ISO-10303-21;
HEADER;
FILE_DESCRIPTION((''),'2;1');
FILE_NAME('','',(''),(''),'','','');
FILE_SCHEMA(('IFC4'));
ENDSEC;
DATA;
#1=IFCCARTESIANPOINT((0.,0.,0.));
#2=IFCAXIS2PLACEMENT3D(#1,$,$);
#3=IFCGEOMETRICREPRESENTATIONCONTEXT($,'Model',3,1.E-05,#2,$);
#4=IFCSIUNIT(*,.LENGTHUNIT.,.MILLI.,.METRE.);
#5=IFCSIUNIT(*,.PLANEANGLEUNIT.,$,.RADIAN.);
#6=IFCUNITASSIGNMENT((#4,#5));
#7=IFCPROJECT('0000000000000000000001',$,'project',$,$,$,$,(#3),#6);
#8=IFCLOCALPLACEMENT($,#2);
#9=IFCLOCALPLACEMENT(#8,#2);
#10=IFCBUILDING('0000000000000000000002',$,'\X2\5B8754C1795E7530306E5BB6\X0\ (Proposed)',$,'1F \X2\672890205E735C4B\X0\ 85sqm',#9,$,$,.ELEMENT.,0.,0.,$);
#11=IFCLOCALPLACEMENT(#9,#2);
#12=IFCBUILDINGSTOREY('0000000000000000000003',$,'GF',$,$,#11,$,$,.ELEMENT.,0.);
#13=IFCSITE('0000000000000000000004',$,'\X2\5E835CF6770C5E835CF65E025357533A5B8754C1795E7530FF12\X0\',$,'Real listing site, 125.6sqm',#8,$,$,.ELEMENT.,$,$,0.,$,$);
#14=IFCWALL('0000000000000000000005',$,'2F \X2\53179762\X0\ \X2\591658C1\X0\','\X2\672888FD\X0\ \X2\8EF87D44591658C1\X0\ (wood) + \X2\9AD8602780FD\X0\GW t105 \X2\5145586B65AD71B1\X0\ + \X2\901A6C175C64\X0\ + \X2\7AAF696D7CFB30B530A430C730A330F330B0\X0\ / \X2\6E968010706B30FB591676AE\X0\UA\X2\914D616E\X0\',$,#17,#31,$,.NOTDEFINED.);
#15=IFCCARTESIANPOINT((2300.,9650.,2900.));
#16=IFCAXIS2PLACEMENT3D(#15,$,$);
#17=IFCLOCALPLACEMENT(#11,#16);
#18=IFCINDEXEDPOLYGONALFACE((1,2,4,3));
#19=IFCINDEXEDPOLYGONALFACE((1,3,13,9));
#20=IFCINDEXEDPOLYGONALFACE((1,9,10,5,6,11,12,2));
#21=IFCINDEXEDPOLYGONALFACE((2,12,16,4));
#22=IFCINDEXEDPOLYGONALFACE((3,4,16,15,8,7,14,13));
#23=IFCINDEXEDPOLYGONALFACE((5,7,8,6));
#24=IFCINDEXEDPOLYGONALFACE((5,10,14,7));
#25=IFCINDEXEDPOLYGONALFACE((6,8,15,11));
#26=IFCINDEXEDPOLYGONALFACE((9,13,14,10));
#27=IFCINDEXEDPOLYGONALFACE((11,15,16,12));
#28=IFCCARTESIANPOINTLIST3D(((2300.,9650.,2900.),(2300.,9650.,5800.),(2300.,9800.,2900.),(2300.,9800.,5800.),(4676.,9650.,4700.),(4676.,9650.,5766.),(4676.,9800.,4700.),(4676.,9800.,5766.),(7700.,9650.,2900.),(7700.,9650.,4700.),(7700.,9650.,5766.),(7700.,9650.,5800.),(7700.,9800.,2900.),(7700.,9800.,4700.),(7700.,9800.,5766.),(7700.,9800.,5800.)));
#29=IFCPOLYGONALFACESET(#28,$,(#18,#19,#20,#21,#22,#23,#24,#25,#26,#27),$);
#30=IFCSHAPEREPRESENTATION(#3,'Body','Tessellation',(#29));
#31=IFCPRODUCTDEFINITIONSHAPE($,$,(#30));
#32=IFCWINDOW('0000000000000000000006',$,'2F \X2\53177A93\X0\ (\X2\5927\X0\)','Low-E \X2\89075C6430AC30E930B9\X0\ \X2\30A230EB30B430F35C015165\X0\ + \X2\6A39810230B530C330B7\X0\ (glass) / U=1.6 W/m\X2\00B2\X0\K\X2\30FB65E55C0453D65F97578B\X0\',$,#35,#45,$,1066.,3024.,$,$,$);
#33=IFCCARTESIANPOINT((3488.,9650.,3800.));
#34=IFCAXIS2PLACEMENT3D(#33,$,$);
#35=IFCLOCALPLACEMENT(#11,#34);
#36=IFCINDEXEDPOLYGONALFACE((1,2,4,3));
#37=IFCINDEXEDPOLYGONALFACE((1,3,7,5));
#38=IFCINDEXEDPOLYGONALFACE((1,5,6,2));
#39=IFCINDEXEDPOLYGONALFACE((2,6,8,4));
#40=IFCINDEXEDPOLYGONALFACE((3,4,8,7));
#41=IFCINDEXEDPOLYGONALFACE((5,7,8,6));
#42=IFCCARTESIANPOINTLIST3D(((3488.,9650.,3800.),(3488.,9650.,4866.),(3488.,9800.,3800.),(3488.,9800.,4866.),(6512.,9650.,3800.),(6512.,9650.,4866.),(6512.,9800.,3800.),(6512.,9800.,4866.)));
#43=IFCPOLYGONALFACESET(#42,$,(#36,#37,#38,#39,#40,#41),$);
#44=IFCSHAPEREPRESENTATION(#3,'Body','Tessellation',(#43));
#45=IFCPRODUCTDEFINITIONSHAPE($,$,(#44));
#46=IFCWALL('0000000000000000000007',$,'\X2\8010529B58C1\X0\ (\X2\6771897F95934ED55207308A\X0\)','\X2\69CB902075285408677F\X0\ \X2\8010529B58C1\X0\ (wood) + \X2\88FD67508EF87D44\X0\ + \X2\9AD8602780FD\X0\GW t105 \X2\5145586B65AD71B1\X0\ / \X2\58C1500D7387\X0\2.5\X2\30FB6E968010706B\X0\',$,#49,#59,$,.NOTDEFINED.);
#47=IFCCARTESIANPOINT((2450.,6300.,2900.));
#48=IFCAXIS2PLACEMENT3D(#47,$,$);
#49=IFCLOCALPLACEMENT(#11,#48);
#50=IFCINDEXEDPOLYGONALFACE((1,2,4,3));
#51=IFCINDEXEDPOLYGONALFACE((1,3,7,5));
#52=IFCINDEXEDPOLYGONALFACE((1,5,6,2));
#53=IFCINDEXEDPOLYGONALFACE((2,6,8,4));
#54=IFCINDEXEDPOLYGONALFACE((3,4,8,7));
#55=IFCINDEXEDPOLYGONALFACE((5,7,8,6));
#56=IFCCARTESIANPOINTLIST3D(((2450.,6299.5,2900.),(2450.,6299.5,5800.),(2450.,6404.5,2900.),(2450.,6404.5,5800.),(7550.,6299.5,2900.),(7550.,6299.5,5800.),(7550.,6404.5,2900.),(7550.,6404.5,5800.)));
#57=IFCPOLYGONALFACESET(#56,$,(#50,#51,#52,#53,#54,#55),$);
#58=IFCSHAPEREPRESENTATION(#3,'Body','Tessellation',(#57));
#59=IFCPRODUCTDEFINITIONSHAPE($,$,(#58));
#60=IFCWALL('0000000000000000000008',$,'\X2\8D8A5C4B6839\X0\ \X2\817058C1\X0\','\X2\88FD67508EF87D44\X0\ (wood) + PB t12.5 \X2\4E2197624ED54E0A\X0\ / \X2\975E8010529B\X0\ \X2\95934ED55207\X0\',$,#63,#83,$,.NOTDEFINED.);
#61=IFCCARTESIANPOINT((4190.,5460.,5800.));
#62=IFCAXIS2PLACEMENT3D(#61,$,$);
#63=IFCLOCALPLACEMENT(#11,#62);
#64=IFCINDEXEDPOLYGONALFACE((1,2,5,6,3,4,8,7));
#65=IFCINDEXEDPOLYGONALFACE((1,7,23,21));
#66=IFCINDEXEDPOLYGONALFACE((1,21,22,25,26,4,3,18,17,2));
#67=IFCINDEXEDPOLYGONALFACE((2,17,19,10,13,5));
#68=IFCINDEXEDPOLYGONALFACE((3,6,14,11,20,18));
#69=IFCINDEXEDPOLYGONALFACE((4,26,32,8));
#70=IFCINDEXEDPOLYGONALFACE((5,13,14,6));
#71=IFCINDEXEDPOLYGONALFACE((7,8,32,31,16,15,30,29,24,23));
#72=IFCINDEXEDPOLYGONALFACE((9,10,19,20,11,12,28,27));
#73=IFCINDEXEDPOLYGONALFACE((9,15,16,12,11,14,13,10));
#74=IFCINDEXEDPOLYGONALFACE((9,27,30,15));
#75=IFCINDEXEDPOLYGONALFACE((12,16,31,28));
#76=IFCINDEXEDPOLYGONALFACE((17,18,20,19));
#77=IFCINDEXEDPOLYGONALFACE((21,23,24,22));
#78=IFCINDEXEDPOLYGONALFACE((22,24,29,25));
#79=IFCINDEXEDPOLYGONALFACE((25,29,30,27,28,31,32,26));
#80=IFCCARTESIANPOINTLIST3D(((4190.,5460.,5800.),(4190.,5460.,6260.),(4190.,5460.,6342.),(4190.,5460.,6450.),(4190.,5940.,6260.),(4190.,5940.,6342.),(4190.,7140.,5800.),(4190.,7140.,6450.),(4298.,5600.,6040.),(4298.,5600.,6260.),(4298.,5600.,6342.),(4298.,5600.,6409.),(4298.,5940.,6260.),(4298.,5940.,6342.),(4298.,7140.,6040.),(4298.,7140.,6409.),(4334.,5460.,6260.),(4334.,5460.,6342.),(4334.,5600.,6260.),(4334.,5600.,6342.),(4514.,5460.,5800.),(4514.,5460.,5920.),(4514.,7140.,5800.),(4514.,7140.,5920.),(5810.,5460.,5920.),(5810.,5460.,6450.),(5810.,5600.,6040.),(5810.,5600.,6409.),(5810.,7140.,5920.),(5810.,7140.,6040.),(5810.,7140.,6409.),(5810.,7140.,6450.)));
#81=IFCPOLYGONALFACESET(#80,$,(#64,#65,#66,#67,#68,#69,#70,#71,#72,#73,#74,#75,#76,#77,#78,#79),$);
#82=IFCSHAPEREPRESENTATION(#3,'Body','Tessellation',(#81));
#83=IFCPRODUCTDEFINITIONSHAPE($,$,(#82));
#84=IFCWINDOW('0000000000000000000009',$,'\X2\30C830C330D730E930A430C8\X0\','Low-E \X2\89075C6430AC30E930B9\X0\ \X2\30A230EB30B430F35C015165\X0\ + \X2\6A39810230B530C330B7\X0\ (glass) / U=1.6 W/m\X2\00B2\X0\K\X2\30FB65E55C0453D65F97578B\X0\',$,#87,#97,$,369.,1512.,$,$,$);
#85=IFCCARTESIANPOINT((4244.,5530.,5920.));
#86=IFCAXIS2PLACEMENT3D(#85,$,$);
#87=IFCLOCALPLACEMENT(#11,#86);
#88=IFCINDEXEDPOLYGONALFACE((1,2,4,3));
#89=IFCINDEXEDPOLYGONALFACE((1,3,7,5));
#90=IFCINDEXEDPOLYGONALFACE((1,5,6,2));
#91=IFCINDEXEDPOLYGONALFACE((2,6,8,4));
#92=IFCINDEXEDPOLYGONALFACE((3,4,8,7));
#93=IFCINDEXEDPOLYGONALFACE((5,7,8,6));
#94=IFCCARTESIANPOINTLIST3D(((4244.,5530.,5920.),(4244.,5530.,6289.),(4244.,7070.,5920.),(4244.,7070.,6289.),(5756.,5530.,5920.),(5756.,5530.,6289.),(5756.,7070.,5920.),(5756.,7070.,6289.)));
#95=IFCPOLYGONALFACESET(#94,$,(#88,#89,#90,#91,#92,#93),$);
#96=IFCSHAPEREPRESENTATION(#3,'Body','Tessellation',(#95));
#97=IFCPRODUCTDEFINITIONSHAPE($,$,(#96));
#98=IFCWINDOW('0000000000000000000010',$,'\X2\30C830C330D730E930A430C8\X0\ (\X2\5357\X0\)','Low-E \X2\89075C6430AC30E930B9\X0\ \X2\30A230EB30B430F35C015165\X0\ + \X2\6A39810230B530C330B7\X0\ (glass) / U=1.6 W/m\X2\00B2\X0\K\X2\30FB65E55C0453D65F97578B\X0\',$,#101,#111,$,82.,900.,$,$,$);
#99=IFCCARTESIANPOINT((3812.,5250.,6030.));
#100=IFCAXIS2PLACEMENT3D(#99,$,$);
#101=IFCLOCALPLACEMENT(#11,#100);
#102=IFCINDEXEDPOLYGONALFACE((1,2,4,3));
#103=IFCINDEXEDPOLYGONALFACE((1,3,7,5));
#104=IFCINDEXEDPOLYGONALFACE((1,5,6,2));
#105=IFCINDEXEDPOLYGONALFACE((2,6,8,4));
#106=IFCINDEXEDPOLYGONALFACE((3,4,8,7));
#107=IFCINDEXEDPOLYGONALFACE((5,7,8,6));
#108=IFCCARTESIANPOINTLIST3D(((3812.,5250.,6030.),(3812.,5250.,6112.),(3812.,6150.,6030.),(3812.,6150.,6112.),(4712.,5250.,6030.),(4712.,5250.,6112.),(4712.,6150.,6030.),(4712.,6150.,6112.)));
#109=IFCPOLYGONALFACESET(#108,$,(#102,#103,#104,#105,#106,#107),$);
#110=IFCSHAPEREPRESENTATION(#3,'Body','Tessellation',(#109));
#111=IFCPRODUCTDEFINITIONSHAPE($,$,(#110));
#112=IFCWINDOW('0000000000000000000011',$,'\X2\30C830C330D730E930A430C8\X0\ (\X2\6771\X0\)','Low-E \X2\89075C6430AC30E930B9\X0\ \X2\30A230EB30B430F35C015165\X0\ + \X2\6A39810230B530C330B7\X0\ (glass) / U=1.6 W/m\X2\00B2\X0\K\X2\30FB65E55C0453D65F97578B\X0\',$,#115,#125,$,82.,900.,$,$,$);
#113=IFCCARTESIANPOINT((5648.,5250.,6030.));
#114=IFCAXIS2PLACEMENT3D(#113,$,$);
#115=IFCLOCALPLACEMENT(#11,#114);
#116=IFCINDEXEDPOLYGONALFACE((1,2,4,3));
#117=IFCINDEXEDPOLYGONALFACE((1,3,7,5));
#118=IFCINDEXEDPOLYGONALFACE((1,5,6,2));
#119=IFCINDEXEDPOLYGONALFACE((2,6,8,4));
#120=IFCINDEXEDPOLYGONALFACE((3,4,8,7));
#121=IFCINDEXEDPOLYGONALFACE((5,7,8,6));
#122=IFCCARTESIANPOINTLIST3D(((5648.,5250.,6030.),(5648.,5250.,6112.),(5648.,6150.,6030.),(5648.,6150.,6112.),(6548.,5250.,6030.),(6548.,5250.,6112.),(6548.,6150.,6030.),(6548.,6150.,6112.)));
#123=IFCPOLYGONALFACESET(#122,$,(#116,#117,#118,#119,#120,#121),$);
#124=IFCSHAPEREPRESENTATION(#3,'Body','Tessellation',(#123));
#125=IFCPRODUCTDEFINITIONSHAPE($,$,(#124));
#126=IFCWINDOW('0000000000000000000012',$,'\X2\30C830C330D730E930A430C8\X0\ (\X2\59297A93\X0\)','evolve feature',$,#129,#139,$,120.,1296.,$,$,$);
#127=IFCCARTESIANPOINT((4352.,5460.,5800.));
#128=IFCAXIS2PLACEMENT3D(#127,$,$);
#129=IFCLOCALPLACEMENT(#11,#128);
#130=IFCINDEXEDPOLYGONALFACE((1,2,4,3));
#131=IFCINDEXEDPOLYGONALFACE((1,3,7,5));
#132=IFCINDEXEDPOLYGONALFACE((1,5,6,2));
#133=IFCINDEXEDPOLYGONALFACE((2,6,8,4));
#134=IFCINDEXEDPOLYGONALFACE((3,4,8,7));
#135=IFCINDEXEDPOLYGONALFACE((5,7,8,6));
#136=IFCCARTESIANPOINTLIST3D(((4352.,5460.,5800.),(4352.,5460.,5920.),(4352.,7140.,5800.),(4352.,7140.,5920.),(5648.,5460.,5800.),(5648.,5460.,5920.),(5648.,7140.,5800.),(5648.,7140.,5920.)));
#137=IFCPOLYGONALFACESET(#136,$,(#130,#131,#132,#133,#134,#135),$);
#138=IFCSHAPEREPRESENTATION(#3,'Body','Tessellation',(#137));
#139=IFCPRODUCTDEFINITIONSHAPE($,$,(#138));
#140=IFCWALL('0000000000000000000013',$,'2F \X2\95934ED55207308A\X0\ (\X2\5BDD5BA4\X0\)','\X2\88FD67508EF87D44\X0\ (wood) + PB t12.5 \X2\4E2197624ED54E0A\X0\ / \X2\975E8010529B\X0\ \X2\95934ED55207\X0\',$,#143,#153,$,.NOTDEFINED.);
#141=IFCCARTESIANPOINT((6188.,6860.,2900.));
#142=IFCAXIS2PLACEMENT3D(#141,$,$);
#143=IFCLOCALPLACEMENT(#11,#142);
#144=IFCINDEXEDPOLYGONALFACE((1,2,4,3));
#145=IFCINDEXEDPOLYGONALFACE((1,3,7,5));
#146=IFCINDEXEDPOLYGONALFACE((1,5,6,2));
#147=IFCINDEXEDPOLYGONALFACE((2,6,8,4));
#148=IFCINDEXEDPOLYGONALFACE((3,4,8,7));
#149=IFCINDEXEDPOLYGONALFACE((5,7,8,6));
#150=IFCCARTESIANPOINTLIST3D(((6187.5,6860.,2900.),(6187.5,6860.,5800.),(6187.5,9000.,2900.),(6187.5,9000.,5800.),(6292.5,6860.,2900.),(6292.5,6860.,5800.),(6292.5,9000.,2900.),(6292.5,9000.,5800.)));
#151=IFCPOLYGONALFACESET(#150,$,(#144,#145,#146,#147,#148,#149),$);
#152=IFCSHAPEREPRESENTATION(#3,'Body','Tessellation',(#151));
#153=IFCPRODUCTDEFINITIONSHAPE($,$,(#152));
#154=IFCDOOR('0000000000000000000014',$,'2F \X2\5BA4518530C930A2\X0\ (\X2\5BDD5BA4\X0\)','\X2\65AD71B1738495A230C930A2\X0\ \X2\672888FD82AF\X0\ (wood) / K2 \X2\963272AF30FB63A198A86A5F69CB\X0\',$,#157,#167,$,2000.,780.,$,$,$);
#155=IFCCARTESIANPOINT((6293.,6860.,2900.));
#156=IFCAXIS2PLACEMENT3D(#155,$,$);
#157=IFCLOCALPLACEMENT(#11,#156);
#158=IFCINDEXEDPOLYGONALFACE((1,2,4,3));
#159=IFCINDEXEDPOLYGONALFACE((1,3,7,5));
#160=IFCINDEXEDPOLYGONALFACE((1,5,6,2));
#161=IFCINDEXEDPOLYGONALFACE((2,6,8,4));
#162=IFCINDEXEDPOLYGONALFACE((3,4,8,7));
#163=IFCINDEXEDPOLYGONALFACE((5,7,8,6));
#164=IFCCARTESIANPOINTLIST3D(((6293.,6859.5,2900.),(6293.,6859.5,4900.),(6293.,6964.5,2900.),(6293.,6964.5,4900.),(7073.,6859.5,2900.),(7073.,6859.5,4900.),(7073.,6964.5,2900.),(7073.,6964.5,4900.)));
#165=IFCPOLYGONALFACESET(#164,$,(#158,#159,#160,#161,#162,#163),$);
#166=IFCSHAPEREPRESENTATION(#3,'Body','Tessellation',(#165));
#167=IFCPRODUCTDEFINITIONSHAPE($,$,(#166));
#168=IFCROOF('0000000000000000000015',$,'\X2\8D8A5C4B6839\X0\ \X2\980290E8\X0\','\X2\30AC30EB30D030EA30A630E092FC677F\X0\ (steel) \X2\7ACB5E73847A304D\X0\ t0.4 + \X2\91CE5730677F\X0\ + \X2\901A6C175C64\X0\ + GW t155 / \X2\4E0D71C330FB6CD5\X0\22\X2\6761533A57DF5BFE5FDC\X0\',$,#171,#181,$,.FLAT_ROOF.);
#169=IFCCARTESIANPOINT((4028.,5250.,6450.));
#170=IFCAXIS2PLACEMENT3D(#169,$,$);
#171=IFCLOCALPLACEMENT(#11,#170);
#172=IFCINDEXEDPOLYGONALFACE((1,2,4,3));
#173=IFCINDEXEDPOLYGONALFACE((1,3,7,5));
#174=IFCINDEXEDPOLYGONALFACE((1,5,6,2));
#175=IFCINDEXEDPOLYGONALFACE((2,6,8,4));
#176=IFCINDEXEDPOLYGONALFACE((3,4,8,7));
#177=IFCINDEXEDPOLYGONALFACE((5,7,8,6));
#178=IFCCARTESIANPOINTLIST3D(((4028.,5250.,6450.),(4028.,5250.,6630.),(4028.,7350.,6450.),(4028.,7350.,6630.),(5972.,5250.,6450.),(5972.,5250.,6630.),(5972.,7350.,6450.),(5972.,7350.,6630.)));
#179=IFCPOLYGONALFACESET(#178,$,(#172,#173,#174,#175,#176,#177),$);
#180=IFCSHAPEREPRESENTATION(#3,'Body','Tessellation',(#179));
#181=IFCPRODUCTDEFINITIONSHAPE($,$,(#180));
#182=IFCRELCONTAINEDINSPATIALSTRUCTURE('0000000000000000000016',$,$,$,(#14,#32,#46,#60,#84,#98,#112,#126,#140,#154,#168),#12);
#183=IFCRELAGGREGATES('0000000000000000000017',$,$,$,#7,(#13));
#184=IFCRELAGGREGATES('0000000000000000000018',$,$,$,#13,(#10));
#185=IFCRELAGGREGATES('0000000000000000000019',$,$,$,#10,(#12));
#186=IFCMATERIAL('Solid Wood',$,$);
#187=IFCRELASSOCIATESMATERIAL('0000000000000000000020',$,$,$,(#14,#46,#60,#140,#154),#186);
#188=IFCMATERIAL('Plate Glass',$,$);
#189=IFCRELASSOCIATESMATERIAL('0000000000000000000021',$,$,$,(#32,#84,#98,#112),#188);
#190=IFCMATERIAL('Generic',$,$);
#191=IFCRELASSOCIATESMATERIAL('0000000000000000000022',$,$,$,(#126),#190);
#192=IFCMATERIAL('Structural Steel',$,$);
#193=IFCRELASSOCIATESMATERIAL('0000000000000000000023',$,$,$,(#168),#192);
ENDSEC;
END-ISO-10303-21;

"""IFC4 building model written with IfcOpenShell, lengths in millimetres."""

from ifc_helpers import new_model, si_unit, frame, frame_2d, origin, place, context, project, spatial, rectangle, extrude, material, element, fill, save


model = new_model("IFC4")

# Units and contexts
model_context = context("Model", 3, precision=1e-05, world=origin())
ifc_project = project(units=[si_unit("LENGTHUNIT", "METRE", prefix="MILLI"), si_unit("PLANEANGLEUNIT", "RADIAN")], contexts=[model_context])

# Site, building, storey
site_placement = place(None, origin())
site = spatial("IfcSite", under=ifc_project, at=site_placement, Name="広島県広島市南区宇品神田２", ObjectType="Real listing site, 125.6sqm", CompositionType="ELEMENT", RefElevation=0.0)
building_placement = place(site_placement, origin())
building = spatial("IfcBuilding", under=site, at=building_placement, Name="宇品神田の家 (Proposed)", ObjectType="1F 木造平屋 85sqm", CompositionType="ELEMENT", ElevationOfRefHeight=0.0, ElevationOfTerrain=0.0)
storey_placement = place(building_placement, origin())
storey = spatial("IfcBuildingStorey", under=building, at=storey_placement, Name="GF", CompositionType="ELEMENT", Elevation=0.0)

# Wall, opening, window
ifc_material_1 = material(Name="Solid Wood")
wall_1_placement = place(storey_placement, frame((2300.0, 9650.0, 2900.0)))
wall_1 = element("IfcWall", 1, at=wall_1_placement, inside=storey, material=ifc_material_1, Name="2F 北面 外壁", Description="木製 軸組外壁 (wood) + 高性能GW t105 充填断熱 + 通気層 + 窯業系サイディング / 準耐火・外皮UA配慮", PredefinedType="NOTDEFINED", context=model_context, shape_type="SweptSolid", body=[
    extrude(rectangle(XDim=5400.0, YDim=150.0, at=frame_2d((2700.0, 75.0))), frame((2300.0, 9650.0, 2900.0)), (0.0, 0.0, 1.0), 2900.0),
])
opening_1_placement = place(storey_placement, frame((3488.0, 9650.0, 3800.0)))
opening_1 = element("IfcOpeningElement", 2, at=opening_1_placement, cuts=wall_1, PredefinedType="NOTDEFINED", context=model_context, shape_type="SweptSolid", body=[
    extrude(rectangle(XDim=3024.0, YDim=150.0, at=frame_2d((1512.0, 75.0))), frame((3488.0, 9650.0, 3800.0)), (0.0, 0.0, 1.0), 1066.0),
])
ifc_material_2 = material(Name="Plate Glass")
window_1_placement = place(storey_placement, frame((3488.0, 9650.0, 3800.0)))
window_1 = element("IfcWindow", 3, at=window_1_placement, inside=storey, material=ifc_material_2, Name="2F 北窓 (大)", Description="Low-E 複層ガラス アルゴン封入 + 樹脂サッシ (glass) / U=1.6 W/m²K・日射取得型", OverallHeight=1066.0, OverallWidth=3024.0, context=model_context, shape_type="SweptSolid", body=[
    extrude(rectangle(XDim=3024.0, YDim=150.0, at=frame_2d((1512.0, 75.0))), frame((3488.0, 9650.0, 3800.0)), (0.0, 0.0, 1.0), 1066.0),
])
fill(opening_1, window_1)

# Wall
wall_2_placement = place(storey_placement, frame((2450.0, 6300.0, 2900.0)))
element("IfcWall", 4, at=wall_2_placement, inside=storey, material=ifc_material_1, Name="耐力壁 (東西間仕切り)", Description="構造用合板 耐力壁 (wood) + 製材軸組 + 高性能GW t105 充填断熱 / 壁倍率2.5・準耐火", PredefinedType="NOTDEFINED", context=model_context, shape_type="SweptSolid", body=[
    extrude(rectangle(XDim=5100.0, YDim=105.0, at=frame_2d((2550.0, 52.0))), frame((2450.0, 6300.0, 2900.0)), (0.0, 0.0, 1.0), 2900.0),
])

# Wall, openings, windows
wall_3_placement = place(storey_placement, frame((4190.0, 5460.0, 5800.0)))
wall_3 = element("IfcWall", 5, at=wall_3_placement, inside=storey, material=ifc_material_1, Name="越屋根 腰壁", Description="製材軸組 (wood) + PB t12.5 両面仕上 / 非耐力 間仕切", PredefinedType="NOTDEFINED", context=model_context, shape_type="SweptSolid", body=[
    extrude(rectangle(XDim=1620.0, YDim=1680.0, at=frame_2d((810.0, 840.0))), frame((4190.0, 5460.0, 5800.0)), (0.0, 0.0, 1.0), 650.0),
])
opening_2_placement = place(storey_placement, frame((4244.0, 5530.0, 5920.0)))
opening_2 = element("IfcOpeningElement", 6, at=opening_2_placement, cuts=wall_3, PredefinedType="NOTDEFINED", context=model_context, shape_type="SweptSolid", body=[
    extrude(rectangle(XDim=1512.0, YDim=1540.0, at=frame_2d((756.0, 770.0))), frame((4244.0, 5530.0, 5920.0)), (0.0, 0.0, 1.0), 369.0),
])
opening_3_placement = place(storey_placement, frame((3812.0, 5250.0, 6030.0)))
opening_3 = element("IfcOpeningElement", 7, at=opening_3_placement, cuts=wall_3, PredefinedType="NOTDEFINED", context=model_context, shape_type="SweptSolid", body=[
    extrude(rectangle(XDim=900.0, YDim=900.0, at=frame_2d((450.0, 450.0))), frame((3812.0, 5250.0, 6030.0)), (0.0, 0.0, 1.0), 82.0),
])
opening_4_placement = place(storey_placement, frame((5648.0, 5250.0, 6030.0)))
opening_4 = element("IfcOpeningElement", 8, at=opening_4_placement, cuts=wall_3, PredefinedType="NOTDEFINED", context=model_context, shape_type="SweptSolid", body=[
    extrude(rectangle(XDim=900.0, YDim=900.0, at=frame_2d((450.0, 450.0))), frame((5648.0, 5250.0, 6030.0)), (0.0, 0.0, 1.0), 82.0),
])
opening_5_placement = place(storey_placement, frame((4352.0, 5460.0, 5800.0)))
opening_5 = element("IfcOpeningElement", 9, at=opening_5_placement, cuts=wall_3, PredefinedType="NOTDEFINED", context=model_context, shape_type="SweptSolid", body=[
    extrude(rectangle(XDim=1296.0, YDim=1680.0, at=frame_2d((648.0, 840.0))), frame((4352.0, 5460.0, 5800.0)), (0.0, 0.0, 1.0), 120.0),
])
window_2_placement = place(storey_placement, frame((4244.0, 5530.0, 5920.0)))
window_2 = element("IfcWindow", 10, at=window_2_placement, inside=storey, material=ifc_material_2, Name="トップライト", Description="Low-E 複層ガラス アルゴン封入 + 樹脂サッシ (glass) / U=1.6 W/m²K・日射取得型", OverallHeight=369.0, OverallWidth=1512.0, context=model_context, shape_type="SweptSolid", body=[
    extrude(rectangle(XDim=1512.0, YDim=1540.0, at=frame_2d((756.0, 770.0))), frame((4244.0, 5530.0, 5920.0)), (0.0, 0.0, 1.0), 369.0),
])
fill(opening_2, window_2)
window_3_placement = place(storey_placement, frame((3812.0, 5250.0, 6030.0)))
window_3 = element("IfcWindow", 11, at=window_3_placement, inside=storey, material=ifc_material_2, Name="トップライト (南)", Description="Low-E 複層ガラス アルゴン封入 + 樹脂サッシ (glass) / U=1.6 W/m²K・日射取得型", OverallHeight=82.0, OverallWidth=900.0, context=model_context, shape_type="SweptSolid", body=[
    extrude(rectangle(XDim=900.0, YDim=900.0, at=frame_2d((450.0, 450.0))), frame((3812.0, 5250.0, 6030.0)), (0.0, 0.0, 1.0), 82.0),
])
fill(opening_3, window_3)
window_4_placement = place(storey_placement, frame((5648.0, 5250.0, 6030.0)))
window_4 = element("IfcWindow", 12, at=window_4_placement, inside=storey, material=ifc_material_2, Name="トップライト (東)", Description="Low-E 複層ガラス アルゴン封入 + 樹脂サッシ (glass) / U=1.6 W/m²K・日射取得型", OverallHeight=82.0, OverallWidth=900.0, context=model_context, shape_type="SweptSolid", body=[
    extrude(rectangle(XDim=900.0, YDim=900.0, at=frame_2d((450.0, 450.0))), frame((5648.0, 5250.0, 6030.0)), (0.0, 0.0, 1.0), 82.0),
])
fill(opening_4, window_4)
ifc_material_3 = material(Name="Generic")
window_5_placement = place(storey_placement, frame((4352.0, 5460.0, 5800.0)))
window_5 = element("IfcWindow", 13, at=window_5_placement, inside=storey, material=ifc_material_3, Name="トップライト (天窓)", Description="evolve feature", OverallHeight=120.0, OverallWidth=1296.0, context=model_context, shape_type="SweptSolid", body=[
    extrude(rectangle(XDim=1296.0, YDim=1680.0, at=frame_2d((648.0, 840.0))), frame((4352.0, 5460.0, 5800.0)), (0.0, 0.0, 1.0), 120.0),
])
fill(opening_5, window_5)

# Wall
wall_4_placement = place(storey_placement, frame((6188.0, 6860.0, 2900.0)))
element("IfcWall", 14, at=wall_4_placement, inside=storey, material=ifc_material_1, Name="2F 間仕切り (寝室)", Description="製材軸組 (wood) + PB t12.5 両面仕上 / 非耐力 間仕切", PredefinedType="NOTDEFINED", context=model_context, shape_type="SweptSolid", body=[
    extrude(rectangle(XDim=105.0, YDim=2140.0, at=frame_2d((52.0, 1070.0))), frame((6188.0, 6860.0, 2900.0)), (0.0, 0.0, 1.0), 2900.0),
])

# Door
door_placement = place(storey_placement, frame((6293.0, 6860.0, 2900.0)))
element("IfcDoor", 15, at=door_placement, inside=storey, material=ifc_material_1, Name="2F 室内ドア (寝室)", Description="断熱玄関ドア 木製芯 (wood) / K2 防犯・採風機構", OverallHeight=2000.0, OverallWidth=780.0, context=model_context, shape_type="SweptSolid", body=[
    extrude(rectangle(XDim=780.0, YDim=105.0, at=frame_2d((390.0, 52.0))), frame((6293.0, 6860.0, 2900.0)), (0.0, 0.0, 1.0), 2000.0),
])

# Roof
ifc_material_4 = material(Name="Structural Steel")
roof_placement = place(storey_placement, frame((4028.0, 5250.0, 6450.0)))
element("IfcRoof", 16, at=roof_placement, inside=storey, material=ifc_material_4, Name="越屋根 頂部", Description="ガルバリウム鋼板 (steel) 立平葺き t0.4 + 野地板 + 通気層 + GW t155 / 不燃・法22条区域対応", PredefinedType="FLAT_ROOF", context=model_context, shape_type="SweptSolid", body=[
    extrude(rectangle(XDim=1944.0, YDim=2100.0, at=frame_2d((972.0, 1050.0))), frame((4028.0, 5250.0, 6450.0)), (0.0, 0.0, 1.0), 180.0),
])

save(model, "model.ifc")
